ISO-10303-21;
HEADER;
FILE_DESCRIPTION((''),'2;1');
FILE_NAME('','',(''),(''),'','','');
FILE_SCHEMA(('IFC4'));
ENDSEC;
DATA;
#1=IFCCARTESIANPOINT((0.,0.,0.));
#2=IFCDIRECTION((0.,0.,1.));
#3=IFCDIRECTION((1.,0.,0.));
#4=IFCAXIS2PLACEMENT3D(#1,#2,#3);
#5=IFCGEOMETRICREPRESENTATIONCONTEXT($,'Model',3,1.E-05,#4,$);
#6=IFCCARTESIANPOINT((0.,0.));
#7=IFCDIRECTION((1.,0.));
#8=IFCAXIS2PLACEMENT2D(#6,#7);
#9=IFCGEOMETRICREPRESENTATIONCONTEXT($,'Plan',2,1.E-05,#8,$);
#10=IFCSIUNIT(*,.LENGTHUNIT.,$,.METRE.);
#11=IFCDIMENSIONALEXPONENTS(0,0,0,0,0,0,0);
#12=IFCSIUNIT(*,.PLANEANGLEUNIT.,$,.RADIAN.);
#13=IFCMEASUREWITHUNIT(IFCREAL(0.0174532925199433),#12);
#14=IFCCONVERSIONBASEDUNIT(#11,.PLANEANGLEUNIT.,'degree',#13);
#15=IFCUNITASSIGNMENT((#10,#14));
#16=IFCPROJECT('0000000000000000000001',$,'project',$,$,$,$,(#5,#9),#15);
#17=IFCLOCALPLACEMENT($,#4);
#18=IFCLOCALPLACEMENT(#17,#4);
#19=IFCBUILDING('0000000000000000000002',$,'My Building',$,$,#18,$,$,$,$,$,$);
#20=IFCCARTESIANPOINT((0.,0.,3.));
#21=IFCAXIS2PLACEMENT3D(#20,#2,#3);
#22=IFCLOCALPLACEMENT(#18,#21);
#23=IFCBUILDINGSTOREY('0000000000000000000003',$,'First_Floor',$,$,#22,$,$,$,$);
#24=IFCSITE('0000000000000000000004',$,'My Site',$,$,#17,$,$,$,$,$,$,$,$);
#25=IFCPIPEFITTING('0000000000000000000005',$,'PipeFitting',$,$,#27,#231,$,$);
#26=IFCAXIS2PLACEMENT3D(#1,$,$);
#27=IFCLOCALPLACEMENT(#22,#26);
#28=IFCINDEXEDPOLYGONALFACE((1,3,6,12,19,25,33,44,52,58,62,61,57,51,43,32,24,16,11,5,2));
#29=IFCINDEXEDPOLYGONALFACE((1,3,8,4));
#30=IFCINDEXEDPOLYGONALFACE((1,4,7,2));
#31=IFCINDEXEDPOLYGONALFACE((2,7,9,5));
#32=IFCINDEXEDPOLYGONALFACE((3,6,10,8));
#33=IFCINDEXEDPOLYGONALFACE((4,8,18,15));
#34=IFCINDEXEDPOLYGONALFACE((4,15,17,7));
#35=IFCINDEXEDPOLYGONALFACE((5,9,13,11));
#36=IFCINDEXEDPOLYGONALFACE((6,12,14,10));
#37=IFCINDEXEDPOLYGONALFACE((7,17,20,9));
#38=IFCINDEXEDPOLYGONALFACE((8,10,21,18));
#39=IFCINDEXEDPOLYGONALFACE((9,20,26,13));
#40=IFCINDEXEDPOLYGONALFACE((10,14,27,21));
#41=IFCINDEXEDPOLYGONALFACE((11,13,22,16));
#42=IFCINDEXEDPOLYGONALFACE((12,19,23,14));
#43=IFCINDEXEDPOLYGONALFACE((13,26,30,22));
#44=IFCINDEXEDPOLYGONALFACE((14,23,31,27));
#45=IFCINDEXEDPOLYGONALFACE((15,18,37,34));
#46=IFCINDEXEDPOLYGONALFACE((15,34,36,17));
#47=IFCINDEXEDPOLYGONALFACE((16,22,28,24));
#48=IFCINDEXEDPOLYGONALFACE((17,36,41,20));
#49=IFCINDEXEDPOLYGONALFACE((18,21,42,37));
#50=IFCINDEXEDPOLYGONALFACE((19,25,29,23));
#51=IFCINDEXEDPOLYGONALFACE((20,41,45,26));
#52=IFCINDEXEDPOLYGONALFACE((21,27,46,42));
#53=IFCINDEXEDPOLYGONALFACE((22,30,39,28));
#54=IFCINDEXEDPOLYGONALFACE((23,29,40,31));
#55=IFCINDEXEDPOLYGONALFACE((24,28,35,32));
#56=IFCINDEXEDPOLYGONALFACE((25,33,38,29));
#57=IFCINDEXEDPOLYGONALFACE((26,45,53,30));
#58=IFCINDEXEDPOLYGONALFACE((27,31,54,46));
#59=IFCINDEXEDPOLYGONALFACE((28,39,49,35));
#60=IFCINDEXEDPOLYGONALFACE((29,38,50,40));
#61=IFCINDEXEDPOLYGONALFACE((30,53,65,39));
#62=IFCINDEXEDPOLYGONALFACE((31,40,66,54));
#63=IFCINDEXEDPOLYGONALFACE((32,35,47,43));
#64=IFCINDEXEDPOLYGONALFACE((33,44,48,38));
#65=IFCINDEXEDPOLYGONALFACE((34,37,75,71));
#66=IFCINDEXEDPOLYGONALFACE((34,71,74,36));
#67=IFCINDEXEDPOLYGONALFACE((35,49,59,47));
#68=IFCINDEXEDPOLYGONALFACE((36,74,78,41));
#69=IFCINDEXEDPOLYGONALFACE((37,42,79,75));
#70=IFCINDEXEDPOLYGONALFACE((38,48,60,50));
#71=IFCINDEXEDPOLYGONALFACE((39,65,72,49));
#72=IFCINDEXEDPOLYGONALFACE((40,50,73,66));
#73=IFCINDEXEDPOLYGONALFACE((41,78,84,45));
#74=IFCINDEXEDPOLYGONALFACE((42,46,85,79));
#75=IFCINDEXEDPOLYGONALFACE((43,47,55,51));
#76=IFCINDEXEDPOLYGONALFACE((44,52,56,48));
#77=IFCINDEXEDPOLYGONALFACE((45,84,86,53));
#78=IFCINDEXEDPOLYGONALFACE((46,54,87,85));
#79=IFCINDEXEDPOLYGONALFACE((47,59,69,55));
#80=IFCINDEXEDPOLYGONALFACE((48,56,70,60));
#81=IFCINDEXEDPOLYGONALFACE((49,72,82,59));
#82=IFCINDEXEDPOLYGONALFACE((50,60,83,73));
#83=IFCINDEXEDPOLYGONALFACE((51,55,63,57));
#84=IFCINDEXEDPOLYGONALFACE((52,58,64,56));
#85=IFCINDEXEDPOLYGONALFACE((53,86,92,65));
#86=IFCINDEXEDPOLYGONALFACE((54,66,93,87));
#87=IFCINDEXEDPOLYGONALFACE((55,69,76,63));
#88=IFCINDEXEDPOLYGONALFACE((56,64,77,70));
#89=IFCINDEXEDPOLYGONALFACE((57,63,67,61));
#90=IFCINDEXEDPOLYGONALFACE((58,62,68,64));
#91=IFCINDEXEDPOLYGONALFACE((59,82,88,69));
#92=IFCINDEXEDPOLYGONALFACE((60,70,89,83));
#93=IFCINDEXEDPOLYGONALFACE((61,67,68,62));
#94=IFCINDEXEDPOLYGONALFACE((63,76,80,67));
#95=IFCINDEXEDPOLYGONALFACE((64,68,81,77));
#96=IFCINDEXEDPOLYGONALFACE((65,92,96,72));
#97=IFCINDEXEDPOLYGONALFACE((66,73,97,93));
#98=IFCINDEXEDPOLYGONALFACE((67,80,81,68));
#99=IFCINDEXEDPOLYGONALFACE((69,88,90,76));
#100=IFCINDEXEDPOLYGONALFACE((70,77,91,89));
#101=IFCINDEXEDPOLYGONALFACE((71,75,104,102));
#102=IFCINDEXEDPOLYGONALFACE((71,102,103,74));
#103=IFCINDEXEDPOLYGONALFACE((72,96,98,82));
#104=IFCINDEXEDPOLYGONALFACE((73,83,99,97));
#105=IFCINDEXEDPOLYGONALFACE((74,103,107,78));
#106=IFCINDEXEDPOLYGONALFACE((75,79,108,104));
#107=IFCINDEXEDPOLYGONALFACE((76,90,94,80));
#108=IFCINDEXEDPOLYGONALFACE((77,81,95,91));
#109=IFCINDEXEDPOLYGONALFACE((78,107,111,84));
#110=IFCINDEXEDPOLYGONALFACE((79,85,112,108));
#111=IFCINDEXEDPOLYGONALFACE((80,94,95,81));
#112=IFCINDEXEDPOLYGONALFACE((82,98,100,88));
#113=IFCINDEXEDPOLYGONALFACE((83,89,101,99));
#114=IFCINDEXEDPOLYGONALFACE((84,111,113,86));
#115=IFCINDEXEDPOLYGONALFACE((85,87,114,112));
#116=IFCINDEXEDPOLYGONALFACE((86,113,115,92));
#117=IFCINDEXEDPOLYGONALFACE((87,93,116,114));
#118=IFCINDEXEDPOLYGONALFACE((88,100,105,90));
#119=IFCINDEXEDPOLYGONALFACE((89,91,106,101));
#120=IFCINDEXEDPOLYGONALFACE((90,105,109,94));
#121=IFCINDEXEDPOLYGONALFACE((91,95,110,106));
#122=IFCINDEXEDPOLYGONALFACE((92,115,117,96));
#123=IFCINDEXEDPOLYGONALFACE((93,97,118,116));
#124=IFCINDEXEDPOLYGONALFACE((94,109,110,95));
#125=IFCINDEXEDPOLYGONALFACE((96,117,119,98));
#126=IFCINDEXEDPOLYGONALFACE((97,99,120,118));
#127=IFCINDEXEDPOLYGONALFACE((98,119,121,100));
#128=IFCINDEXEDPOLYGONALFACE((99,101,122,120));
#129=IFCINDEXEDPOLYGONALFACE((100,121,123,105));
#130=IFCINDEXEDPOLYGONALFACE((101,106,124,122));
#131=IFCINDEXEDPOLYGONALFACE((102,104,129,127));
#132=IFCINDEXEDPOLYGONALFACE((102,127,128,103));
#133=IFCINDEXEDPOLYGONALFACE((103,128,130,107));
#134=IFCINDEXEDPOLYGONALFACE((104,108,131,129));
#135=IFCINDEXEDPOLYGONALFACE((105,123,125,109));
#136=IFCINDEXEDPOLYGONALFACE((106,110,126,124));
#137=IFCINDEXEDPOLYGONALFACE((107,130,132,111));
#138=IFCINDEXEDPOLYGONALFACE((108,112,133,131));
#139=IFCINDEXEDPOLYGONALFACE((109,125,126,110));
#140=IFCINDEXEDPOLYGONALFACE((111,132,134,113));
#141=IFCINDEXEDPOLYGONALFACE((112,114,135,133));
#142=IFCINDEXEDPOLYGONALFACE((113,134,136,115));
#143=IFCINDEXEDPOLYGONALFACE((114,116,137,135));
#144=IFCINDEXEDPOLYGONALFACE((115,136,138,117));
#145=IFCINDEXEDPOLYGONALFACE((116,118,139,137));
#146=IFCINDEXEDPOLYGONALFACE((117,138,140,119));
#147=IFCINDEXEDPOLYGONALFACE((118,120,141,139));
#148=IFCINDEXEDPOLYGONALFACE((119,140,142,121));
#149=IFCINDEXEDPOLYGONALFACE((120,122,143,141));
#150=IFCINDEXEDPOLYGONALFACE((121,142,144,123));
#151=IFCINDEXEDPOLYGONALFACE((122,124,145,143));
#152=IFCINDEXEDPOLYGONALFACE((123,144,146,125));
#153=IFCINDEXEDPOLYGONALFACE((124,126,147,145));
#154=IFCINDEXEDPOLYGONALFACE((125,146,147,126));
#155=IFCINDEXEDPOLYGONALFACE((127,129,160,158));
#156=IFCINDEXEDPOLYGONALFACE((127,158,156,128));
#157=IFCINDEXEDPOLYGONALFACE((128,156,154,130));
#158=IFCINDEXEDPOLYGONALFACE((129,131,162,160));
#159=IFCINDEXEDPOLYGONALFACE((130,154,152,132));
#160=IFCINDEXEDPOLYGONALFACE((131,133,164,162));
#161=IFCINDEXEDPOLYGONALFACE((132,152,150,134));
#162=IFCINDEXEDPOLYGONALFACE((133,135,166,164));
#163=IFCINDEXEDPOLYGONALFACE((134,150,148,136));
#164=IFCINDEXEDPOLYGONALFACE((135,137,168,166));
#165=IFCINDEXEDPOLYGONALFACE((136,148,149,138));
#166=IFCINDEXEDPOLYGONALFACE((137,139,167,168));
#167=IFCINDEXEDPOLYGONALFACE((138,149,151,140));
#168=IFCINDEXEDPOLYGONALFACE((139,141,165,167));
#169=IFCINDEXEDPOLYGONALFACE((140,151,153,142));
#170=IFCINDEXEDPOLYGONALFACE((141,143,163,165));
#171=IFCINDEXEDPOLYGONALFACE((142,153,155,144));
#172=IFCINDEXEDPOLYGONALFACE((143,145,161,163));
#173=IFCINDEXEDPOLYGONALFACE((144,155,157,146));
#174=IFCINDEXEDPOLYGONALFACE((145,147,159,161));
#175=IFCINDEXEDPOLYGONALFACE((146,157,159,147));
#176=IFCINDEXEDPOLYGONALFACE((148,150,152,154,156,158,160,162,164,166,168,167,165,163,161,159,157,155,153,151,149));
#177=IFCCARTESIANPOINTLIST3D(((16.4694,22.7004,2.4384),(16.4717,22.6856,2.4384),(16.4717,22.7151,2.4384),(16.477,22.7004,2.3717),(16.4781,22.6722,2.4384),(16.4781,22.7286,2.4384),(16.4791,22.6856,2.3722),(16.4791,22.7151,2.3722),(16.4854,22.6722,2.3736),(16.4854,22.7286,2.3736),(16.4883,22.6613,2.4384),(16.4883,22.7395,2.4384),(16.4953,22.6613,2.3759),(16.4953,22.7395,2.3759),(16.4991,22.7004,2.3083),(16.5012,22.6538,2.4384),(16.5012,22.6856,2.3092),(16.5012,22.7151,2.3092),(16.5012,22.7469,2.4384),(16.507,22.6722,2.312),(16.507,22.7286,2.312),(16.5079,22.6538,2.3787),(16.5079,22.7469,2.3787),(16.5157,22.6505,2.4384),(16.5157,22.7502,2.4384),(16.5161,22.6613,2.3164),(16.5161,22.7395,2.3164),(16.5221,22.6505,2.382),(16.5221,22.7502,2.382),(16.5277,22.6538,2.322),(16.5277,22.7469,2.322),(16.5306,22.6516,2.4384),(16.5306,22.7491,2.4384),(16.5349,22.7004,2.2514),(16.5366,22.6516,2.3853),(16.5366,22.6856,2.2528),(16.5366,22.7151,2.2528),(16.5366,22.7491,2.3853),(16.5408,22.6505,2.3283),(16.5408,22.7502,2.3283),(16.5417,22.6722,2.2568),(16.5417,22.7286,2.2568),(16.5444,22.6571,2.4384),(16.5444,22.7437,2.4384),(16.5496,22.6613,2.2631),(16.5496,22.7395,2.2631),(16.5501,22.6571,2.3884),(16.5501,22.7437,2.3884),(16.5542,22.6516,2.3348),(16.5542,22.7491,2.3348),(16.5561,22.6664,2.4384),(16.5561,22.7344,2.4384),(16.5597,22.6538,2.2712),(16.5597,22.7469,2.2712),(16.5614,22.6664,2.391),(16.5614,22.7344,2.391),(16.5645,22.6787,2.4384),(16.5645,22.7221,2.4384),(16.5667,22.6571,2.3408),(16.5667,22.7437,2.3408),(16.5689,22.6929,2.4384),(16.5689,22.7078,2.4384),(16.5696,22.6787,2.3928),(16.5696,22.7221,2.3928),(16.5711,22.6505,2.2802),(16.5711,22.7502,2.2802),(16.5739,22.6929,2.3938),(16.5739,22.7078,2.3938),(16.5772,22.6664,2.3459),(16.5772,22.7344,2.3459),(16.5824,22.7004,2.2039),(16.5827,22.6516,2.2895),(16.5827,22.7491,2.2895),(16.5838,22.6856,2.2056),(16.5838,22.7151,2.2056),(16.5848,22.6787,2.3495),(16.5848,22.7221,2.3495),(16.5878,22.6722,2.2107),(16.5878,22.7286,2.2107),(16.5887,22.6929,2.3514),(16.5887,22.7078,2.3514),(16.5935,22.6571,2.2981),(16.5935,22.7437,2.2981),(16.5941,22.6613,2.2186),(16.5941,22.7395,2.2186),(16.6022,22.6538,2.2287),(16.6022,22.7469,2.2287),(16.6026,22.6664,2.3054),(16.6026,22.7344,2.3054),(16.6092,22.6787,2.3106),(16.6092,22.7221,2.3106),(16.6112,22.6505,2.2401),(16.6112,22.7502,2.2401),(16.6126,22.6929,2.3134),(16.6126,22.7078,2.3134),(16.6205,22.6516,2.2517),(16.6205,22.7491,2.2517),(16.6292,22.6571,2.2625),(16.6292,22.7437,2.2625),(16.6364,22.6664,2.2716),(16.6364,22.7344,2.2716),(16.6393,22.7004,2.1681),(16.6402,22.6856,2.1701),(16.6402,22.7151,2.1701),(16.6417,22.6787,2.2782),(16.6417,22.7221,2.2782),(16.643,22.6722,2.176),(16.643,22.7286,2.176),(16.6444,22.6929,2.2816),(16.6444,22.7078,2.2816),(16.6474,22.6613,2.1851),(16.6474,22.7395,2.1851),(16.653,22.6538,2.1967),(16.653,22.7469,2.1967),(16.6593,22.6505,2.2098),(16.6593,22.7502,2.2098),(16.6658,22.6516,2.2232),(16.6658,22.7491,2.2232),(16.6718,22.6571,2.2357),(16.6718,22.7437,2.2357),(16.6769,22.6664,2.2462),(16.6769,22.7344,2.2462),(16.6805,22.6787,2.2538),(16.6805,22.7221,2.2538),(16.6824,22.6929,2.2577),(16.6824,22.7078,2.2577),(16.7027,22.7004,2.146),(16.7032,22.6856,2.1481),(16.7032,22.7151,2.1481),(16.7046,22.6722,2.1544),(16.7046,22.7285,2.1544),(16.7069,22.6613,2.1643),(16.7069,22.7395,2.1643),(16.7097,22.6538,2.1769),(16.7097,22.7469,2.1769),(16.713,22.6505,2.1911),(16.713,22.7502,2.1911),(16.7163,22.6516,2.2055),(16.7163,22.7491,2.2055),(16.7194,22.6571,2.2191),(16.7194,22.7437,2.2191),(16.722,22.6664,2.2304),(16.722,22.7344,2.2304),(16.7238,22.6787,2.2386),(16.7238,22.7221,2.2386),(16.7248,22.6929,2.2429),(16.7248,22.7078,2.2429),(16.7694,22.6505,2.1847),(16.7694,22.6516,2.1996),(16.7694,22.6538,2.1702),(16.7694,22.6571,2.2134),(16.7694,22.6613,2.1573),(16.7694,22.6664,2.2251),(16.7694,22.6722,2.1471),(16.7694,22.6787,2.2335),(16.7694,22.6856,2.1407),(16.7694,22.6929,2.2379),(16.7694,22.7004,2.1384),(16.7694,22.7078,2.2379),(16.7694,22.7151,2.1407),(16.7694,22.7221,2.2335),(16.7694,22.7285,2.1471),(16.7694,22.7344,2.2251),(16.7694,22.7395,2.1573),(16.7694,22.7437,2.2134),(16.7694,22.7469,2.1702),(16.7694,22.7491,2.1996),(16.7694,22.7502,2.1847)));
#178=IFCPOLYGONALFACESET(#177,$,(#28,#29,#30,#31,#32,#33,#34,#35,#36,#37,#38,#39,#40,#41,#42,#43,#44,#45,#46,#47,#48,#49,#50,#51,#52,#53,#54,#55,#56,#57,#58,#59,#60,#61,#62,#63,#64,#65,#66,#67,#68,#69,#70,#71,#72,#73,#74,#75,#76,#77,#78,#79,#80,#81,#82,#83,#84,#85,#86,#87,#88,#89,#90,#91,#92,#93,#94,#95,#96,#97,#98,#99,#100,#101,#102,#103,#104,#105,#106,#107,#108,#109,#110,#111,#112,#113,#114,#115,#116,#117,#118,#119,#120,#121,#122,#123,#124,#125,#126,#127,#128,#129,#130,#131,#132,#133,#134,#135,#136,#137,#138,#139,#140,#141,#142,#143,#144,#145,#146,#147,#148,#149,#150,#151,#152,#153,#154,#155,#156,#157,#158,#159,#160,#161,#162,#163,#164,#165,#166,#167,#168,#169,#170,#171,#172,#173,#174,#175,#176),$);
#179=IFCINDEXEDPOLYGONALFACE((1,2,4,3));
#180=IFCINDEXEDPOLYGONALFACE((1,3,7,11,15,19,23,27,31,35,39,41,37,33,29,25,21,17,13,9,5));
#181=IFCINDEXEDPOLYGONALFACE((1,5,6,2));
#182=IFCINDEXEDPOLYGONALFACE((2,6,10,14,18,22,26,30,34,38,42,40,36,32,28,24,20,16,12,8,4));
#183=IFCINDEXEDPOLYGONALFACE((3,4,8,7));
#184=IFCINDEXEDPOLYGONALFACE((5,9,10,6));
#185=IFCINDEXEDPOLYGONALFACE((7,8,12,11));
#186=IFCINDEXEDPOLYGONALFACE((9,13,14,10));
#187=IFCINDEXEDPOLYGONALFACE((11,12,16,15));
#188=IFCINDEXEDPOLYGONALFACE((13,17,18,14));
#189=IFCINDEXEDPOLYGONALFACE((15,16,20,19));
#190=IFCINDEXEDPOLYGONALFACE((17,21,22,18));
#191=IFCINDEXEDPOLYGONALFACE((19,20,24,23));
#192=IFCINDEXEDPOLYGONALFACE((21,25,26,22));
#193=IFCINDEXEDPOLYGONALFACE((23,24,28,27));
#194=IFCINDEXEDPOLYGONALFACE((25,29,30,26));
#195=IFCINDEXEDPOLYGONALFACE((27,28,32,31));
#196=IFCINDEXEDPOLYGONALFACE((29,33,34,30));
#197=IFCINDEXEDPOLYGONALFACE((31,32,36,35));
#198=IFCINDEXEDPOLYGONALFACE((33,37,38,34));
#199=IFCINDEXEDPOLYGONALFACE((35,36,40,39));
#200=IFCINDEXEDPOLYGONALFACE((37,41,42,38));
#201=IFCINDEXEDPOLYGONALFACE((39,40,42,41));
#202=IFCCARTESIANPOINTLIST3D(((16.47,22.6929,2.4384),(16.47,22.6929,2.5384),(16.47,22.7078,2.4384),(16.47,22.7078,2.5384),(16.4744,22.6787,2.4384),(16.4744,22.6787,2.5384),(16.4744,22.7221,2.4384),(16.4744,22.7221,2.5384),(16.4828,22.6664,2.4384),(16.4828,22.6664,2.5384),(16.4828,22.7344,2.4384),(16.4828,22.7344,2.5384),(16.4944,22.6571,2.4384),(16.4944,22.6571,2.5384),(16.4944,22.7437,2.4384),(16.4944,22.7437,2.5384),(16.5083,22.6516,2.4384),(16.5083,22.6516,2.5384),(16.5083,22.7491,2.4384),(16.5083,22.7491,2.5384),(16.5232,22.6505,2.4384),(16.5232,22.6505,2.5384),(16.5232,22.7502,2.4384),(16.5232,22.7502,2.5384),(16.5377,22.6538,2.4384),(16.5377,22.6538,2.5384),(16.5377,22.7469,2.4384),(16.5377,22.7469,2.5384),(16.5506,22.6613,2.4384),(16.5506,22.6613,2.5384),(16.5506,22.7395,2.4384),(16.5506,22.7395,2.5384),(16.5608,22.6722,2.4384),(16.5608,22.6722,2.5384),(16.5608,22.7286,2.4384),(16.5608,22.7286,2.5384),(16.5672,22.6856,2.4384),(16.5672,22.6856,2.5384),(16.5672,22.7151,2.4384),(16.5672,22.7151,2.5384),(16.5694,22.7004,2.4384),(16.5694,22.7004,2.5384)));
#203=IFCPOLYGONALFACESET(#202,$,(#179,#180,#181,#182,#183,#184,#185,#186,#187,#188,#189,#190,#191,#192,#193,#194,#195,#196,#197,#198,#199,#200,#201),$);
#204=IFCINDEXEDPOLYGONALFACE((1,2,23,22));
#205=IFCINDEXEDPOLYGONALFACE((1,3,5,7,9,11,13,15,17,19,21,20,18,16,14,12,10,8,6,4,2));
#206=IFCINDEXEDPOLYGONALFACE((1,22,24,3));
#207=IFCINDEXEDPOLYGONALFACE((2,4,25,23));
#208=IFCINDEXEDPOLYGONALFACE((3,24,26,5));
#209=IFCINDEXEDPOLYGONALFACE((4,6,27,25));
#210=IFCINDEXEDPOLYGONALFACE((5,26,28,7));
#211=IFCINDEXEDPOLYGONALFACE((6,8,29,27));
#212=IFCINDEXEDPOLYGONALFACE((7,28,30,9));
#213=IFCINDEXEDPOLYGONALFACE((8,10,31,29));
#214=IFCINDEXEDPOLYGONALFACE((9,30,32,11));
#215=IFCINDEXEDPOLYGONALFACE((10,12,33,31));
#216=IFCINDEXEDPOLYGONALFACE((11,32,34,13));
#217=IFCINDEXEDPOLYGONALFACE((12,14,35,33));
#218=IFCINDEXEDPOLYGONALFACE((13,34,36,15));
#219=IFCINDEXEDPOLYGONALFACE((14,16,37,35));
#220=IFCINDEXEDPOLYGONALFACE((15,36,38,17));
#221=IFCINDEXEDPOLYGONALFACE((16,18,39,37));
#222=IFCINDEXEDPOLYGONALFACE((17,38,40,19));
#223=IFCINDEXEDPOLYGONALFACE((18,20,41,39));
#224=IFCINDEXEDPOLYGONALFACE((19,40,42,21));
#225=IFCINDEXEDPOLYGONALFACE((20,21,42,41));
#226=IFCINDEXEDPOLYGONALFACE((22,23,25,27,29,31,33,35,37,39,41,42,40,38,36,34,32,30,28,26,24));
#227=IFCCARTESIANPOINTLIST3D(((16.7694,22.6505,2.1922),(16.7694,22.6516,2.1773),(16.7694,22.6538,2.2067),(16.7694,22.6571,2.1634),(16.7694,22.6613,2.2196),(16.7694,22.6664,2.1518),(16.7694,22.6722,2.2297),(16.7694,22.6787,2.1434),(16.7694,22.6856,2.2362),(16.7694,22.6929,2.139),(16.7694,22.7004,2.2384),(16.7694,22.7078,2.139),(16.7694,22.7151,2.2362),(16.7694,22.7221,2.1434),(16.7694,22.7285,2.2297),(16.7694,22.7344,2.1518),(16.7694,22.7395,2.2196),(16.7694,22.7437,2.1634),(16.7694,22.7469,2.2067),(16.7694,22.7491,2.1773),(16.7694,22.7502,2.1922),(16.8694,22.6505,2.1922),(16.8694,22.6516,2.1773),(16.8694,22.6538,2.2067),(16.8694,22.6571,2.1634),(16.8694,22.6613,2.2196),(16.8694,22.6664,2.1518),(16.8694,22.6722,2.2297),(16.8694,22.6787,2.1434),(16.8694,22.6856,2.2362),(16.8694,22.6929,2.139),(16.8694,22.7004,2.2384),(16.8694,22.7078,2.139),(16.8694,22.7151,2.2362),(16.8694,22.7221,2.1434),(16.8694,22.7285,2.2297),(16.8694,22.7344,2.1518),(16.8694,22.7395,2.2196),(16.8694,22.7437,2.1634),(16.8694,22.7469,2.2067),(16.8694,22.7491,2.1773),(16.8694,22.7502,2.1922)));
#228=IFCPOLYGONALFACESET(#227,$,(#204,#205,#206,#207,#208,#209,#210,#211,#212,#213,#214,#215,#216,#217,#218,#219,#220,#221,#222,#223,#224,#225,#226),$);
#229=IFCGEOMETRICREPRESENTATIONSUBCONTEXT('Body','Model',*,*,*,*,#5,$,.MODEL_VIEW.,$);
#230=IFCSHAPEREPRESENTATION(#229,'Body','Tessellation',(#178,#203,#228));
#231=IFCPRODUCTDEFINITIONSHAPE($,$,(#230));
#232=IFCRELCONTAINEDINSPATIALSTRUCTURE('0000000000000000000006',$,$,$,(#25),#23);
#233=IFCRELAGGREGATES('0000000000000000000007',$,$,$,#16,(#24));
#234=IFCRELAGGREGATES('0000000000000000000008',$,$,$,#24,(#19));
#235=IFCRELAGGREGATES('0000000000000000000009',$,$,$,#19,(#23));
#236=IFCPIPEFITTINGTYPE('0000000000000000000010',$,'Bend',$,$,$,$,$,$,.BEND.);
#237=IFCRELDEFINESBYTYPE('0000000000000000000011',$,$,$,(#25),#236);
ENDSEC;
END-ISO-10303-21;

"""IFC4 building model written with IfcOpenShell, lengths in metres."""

from ifc_helpers import new_model, entity, si_unit, converted_unit, frame, origin_with_axes, origin_2d_with_axis, place, context, subcontext, project, spatial, circle, extrude, source, transform, mapped, type_object, type_shapes, element, save


model = new_model("IFC4")

# Units and contexts
model_context = context("Model", 3, precision=1e-05, world=origin_with_axes())
plan_context = context("Plan", 2, precision=1e-05, world=origin_2d_with_axis())
body_context = subcontext(model_context, "Body", "Model", "MODEL_VIEW")
ifc_project = project(units=[si_unit("LENGTHUNIT", "METRE"), converted_unit("PLANEANGLEUNIT", "degree", entity("IfcReal", 0.0174532925199433), si_unit("PLANEANGLEUNIT", "RADIAN"), dimensions=[0, 0, 0, 0, 0, 0, 0])], contexts=[model_context, plan_context])

# Site, building, storey
site_placement = place(None, origin_with_axes())
site = spatial("IfcSite", under=ifc_project, at=site_placement, Name="My Site")
building_placement = place(site_placement, origin_with_axes())
building = spatial("IfcBuilding", under=site, at=building_placement, Name="My Building")
storey_placement = place(building_placement, frame((0.0, 0.0, 3.0), z_axis=(0.0, 0.0, 1.0), x_axis=(1.0, 0.0, 0.0)))
storey = spatial("IfcBuildingStorey", under=building, at=storey_placement, Name="First_Floor")

# Pipe fitting
pipe_fitting_type = type_object("IfcPipeFittingType", Name="Bend", PredefinedType="BEND")
shared_shape = source(origin_with_axes(), body_context, "Body", "SolidModel", [
    entity("IfcSweptDiskSolid", entity("IfcIndexedPolyCurve", entity("IfcCartesianPointList3D", [[0.0, 0.0, -0.1], [0.0732, 0.0, -0.2768], [0.25, 0.0, -0.35]]), [entity("IfcArcIndex", [1, 2, 3])]), 0.05),
    extrude(circle(Radius=0.05), origin_with_axes(), (0.0, 0.0, -1.0), 0.1),
    extrude(circle(Radius=0.05), frame((0.25, 0.0, -0.35), z_axis=(1.0, 0.0, 0.0), x_axis=(0.0, 0.0, 1.0)), (0.0, 0.0, 1.0), 0.1),
])
type_shapes(pipe_fitting_type, [shared_shape])
for number, where, z_axis, x_axis, name in (
    (1, (16.5194, 22.7004, 2.5384), (0.0, 0.0, 1.0), (1.0, 0.0, 0.0), "PipeFitting"),
):
    element("IfcPipeFitting", number, at=place(storey_placement, frame(where, z_axis=z_axis, x_axis=x_axis)), inside=storey, type_object=pipe_fitting_type, Name=name, context=body_context, shape_type="MappedRepresentation", body=[
        mapped(shared_shape, transform((0.0, 0.0, 0.0), x_axis=(1.0, 0.0, 0.0), y_axis=(0.0, 1.0, 0.0), z_axis=(0.0, 0.0, 1.0), scale=1.0)),
    ])

save(model, "model.ifc")
